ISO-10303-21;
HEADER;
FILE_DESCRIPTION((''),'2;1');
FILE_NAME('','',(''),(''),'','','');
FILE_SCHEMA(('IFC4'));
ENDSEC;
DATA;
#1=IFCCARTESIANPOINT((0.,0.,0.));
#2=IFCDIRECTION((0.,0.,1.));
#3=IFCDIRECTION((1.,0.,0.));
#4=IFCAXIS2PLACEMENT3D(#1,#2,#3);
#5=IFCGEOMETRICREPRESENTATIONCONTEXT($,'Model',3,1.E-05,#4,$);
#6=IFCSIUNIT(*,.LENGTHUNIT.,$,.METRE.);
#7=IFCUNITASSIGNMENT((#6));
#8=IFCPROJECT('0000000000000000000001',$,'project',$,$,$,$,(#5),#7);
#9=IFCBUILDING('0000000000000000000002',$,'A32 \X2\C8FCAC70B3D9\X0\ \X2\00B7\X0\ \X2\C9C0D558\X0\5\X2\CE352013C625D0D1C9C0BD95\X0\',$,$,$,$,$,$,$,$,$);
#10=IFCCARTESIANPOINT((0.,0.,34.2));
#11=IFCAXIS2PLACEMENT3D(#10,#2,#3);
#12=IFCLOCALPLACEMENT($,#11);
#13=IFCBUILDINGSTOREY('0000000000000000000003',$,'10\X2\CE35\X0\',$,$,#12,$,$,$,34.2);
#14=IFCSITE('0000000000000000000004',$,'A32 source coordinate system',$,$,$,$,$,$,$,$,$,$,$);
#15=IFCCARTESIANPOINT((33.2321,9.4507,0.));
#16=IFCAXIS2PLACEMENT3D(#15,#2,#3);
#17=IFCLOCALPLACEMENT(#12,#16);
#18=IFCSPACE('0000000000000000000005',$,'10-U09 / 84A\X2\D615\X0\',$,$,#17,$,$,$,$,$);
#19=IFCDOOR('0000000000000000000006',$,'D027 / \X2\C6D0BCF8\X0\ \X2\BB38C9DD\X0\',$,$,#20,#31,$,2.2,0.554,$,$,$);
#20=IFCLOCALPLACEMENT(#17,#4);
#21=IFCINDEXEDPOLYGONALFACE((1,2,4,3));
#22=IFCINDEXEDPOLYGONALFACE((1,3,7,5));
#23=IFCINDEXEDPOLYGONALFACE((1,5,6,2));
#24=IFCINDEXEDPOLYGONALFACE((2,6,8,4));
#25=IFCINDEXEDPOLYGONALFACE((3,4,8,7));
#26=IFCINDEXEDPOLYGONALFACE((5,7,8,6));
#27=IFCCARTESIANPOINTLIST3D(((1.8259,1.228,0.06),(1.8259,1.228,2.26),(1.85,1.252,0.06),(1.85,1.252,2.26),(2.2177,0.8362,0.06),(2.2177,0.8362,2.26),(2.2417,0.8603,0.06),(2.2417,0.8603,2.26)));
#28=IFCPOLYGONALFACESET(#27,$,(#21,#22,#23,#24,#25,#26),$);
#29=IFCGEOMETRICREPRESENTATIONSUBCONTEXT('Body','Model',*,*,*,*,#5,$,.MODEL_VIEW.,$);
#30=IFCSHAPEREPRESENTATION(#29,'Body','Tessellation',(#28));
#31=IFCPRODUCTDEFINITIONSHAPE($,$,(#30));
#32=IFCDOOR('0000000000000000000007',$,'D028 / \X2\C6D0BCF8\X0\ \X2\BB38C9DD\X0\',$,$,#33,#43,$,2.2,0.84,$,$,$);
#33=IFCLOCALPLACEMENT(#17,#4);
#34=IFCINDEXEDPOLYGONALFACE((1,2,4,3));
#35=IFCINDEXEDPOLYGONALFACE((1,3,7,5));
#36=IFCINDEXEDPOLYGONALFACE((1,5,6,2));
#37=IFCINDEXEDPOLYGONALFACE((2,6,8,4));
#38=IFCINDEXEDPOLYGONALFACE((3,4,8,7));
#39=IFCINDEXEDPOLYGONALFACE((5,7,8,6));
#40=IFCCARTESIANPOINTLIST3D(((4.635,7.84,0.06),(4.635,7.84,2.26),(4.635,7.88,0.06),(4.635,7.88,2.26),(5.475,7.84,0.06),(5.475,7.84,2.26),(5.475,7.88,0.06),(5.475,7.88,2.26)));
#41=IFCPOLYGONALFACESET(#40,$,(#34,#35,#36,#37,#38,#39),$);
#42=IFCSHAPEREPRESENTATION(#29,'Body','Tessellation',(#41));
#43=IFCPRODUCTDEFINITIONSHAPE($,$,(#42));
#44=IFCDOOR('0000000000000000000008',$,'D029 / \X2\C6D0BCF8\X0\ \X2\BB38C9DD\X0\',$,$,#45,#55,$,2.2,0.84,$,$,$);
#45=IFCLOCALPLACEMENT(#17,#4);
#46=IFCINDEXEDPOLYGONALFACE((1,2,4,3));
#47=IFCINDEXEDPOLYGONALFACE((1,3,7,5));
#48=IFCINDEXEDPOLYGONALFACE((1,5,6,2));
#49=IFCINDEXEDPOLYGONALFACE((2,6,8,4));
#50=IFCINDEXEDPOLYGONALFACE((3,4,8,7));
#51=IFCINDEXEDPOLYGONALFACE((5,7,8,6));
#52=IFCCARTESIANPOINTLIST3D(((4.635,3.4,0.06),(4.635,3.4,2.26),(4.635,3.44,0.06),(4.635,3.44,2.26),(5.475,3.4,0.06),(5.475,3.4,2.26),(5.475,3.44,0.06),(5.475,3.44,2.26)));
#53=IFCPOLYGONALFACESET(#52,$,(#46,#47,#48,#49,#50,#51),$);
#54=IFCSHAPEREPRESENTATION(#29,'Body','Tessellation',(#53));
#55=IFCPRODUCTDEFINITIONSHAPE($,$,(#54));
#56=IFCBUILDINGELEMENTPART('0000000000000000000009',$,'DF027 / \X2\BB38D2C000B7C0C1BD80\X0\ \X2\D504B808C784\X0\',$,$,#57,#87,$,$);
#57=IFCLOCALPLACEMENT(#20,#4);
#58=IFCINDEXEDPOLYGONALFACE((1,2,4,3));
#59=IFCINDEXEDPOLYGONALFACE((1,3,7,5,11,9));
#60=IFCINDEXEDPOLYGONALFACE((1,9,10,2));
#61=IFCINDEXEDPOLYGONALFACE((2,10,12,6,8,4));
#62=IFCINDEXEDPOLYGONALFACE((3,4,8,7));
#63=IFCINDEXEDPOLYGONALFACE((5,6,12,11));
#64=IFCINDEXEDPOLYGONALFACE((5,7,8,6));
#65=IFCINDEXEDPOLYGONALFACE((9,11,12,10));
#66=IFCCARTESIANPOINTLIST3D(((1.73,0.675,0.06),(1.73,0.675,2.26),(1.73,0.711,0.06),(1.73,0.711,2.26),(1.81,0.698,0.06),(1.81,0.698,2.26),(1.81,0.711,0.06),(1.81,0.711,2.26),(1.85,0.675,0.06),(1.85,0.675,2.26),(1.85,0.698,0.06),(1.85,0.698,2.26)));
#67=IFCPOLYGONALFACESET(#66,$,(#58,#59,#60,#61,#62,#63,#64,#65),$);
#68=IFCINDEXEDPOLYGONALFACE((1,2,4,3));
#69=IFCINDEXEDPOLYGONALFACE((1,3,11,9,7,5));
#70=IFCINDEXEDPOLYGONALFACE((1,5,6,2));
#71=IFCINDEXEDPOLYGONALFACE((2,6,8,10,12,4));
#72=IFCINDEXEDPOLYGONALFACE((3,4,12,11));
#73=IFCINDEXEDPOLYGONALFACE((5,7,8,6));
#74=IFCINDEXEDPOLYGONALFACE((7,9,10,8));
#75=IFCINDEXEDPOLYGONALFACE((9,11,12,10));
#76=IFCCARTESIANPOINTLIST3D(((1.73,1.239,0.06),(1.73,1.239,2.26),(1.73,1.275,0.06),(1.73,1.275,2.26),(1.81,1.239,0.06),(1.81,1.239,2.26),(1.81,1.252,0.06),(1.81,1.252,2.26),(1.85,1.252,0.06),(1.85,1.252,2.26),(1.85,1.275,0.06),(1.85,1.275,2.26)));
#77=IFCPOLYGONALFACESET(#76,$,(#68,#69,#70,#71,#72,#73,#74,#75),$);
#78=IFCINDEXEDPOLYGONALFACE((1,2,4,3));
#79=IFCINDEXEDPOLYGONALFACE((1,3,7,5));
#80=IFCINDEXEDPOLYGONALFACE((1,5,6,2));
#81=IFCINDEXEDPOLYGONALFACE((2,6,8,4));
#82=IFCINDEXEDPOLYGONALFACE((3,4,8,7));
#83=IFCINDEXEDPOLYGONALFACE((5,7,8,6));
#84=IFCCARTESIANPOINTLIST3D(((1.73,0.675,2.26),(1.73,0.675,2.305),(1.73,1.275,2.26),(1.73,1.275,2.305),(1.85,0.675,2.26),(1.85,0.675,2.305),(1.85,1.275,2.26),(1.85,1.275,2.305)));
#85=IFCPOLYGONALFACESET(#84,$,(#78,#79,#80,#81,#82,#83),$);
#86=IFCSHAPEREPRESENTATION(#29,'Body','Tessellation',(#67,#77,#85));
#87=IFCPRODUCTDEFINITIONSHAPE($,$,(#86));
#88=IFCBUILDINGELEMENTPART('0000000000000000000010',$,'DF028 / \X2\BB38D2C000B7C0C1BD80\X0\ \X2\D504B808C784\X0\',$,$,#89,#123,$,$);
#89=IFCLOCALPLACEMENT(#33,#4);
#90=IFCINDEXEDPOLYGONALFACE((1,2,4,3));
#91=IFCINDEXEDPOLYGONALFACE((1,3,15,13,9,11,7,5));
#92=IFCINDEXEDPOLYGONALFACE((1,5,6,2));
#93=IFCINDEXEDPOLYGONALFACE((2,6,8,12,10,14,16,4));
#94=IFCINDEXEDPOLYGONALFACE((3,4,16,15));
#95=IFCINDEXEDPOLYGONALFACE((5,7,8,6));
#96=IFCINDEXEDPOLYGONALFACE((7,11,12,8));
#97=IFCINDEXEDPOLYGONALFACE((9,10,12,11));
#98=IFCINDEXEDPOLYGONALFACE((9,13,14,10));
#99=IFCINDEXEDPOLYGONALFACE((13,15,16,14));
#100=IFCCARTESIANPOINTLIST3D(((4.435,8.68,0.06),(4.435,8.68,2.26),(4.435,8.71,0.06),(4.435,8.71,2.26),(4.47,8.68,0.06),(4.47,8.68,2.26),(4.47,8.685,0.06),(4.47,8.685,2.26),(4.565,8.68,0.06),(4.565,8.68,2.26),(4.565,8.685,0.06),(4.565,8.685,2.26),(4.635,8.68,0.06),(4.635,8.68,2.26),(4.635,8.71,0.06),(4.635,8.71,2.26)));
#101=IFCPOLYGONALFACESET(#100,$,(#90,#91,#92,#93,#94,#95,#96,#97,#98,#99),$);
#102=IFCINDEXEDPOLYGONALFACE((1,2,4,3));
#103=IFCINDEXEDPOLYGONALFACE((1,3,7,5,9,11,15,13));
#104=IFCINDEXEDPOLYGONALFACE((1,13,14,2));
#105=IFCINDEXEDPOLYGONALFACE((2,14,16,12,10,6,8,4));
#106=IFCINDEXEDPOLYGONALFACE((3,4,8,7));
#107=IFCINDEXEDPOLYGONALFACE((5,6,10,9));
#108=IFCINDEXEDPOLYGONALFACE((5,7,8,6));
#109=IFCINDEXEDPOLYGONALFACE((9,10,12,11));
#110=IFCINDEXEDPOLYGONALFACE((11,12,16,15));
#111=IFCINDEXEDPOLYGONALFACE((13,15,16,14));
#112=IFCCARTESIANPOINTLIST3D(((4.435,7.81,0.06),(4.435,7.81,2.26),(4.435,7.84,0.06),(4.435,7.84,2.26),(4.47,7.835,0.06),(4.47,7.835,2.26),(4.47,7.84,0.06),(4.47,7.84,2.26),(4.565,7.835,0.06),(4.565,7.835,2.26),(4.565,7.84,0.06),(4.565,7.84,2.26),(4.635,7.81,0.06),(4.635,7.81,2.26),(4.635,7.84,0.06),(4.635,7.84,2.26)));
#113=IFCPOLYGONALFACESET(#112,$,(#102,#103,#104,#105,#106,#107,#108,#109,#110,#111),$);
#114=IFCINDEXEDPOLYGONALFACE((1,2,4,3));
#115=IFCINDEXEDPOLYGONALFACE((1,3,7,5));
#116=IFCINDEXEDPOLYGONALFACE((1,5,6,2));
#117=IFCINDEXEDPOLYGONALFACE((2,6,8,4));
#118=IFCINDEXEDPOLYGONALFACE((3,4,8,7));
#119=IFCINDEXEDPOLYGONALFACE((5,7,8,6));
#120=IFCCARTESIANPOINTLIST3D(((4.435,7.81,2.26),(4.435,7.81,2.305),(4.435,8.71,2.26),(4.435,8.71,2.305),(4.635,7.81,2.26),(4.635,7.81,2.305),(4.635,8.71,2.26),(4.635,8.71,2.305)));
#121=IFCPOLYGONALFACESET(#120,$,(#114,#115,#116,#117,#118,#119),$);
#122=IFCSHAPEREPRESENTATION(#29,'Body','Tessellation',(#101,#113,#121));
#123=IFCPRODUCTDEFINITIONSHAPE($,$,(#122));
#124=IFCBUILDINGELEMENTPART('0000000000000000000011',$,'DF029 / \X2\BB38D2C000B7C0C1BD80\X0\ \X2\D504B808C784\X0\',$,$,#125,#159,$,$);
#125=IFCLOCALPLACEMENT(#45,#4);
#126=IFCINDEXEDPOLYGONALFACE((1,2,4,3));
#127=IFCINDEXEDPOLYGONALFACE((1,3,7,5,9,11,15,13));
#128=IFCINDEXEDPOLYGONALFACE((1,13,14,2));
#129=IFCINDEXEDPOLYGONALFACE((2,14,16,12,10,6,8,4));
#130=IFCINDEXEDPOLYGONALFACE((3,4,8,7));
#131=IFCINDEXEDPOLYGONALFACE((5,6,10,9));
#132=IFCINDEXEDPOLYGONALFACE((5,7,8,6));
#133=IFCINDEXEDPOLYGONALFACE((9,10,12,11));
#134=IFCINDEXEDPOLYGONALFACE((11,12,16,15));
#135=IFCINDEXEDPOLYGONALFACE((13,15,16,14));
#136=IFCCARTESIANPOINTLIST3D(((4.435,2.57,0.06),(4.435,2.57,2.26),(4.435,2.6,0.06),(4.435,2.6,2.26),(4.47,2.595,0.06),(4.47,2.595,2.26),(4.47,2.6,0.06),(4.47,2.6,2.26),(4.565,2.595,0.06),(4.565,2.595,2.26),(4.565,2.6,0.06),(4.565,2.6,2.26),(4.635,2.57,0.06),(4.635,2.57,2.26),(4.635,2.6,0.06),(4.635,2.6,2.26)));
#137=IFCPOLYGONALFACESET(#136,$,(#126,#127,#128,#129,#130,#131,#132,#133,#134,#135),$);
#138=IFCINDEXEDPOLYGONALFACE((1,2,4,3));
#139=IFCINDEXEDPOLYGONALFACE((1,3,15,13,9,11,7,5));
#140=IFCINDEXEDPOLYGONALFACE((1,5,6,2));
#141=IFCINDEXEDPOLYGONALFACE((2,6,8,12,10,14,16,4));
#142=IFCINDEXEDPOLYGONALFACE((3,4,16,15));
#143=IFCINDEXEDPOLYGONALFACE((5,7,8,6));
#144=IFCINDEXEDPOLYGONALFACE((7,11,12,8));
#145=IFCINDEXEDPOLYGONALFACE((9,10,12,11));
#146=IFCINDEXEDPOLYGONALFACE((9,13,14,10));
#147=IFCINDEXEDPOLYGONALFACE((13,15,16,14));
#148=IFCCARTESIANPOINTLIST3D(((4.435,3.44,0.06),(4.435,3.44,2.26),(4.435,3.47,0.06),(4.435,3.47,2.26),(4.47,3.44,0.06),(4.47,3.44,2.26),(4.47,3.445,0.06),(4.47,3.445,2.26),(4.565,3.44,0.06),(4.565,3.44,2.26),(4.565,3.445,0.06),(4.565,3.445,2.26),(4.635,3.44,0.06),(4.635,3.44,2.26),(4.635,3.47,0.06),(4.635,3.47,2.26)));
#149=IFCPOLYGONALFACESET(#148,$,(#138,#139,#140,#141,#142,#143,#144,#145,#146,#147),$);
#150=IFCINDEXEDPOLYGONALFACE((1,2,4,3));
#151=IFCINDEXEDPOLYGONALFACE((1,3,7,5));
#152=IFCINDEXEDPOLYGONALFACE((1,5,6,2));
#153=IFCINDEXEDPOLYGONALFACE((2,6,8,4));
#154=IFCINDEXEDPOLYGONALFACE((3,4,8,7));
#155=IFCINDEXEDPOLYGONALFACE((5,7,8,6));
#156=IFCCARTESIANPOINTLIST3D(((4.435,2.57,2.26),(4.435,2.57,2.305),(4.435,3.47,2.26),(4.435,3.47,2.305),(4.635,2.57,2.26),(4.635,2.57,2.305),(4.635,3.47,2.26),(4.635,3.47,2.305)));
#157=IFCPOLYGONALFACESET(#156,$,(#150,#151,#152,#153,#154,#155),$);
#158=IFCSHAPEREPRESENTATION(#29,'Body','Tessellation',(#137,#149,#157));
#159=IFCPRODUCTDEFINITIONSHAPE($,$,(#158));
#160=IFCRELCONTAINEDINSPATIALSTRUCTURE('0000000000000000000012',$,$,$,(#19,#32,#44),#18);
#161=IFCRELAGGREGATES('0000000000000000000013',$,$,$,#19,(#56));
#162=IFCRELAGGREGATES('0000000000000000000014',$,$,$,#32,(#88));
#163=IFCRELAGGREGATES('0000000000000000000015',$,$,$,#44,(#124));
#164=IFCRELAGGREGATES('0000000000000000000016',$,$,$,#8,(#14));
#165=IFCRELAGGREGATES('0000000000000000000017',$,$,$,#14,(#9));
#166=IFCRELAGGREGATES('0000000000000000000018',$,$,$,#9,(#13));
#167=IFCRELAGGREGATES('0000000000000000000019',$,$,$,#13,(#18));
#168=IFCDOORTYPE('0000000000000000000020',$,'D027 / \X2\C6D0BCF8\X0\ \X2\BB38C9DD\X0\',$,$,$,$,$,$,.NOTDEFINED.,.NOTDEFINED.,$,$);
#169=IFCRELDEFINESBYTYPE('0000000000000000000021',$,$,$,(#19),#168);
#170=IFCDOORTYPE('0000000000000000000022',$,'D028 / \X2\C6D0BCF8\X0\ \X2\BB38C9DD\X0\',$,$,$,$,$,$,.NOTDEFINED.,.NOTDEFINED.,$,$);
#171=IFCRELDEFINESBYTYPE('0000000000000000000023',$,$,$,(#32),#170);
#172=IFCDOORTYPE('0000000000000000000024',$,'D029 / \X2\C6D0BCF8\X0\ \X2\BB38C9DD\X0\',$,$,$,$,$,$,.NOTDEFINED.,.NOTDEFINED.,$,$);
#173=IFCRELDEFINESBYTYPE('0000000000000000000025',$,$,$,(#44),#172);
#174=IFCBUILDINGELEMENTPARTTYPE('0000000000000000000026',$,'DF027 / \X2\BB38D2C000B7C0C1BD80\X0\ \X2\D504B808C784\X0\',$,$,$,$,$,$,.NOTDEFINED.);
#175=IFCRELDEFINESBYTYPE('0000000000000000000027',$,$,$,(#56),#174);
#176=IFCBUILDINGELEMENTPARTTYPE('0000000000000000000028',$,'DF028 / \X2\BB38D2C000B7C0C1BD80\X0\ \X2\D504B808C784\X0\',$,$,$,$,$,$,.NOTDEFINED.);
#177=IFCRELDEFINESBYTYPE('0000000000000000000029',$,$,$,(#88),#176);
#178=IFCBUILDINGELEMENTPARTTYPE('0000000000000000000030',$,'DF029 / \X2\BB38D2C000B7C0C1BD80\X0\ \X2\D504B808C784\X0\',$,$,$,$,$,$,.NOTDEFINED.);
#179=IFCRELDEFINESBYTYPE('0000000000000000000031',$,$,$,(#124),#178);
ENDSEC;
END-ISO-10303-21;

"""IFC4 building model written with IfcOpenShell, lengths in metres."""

from ifc_helpers import new_model, si_unit, frame, origin, origin_with_axes, place, context, subcontext, project, spatial, polyline, outline, extrude, source, transform, mapped, type_object, type_shapes, element, aggregate, save


model = new_model("IFC4")

# Units and contexts
model_context = context("Model", 3, precision=1e-05, world=origin_with_axes())
body_context = subcontext(model_context, "Body", "Model", "MODEL_VIEW")
ifc_project = project(units=[si_unit("LENGTHUNIT", "METRE")], contexts=[model_context])

# Site, building, storey, space
storey_placement = place(None, frame((0.0, 0.0, 34.2), z_axis=(0.0, 0.0, 1.0), x_axis=(1.0, 0.0, 0.0)))
space_placement = place(storey_placement, frame((33.2321, 9.4507, 0.0), z_axis=(0.0, 0.0, 1.0), x_axis=(1.0, 0.0, 0.0)))
site = spatial("IfcSite", under=ifc_project, Name="A32 source coordinate system")
building = spatial("IfcBuilding", under=site, Name="A32 주거동 · 지하5층–옥탑지붕")
storey = spatial("IfcBuildingStorey", under=building, at=storey_placement, Name="10층", Elevation=34.2)
space = spatial("IfcSpace", under=storey, at=space_placement, Name="10-U09 / 84A형")

# Doors
door_type_1 = type_object("IfcDoorType", Name="D027 / 원본 문짝", OperationType="NOTDEFINED", PredefinedType="NOTDEFINED")
shared_shape_1 = source(origin(), body_context, "Body", "SweptSolid", [
    extrude(outline(polyline([(1.85, 1.252), (2.2417, 0.8603), (2.2177, 0.8362), (1.8259, 1.228), (1.85, 1.252)])), frame((0.0, 0.0, 0.06)), (0.0, 0.0, 1.0), 2.2),
])
type_shapes(door_type_1, [shared_shape_1])
door_1_placement = place(space_placement, origin_with_axes())
door_1 = element("IfcDoor", 1, at=door_1_placement, inside=space, type_object=door_type_1, Name="D027 / 원본 문짝", OverallHeight=2.2, OverallWidth=0.554, context=body_context, shape_type="MappedRepresentation", body=[
    mapped(shared_shape_1, transform((0.0, 0.0, 0.0), scale=1.0)),
])
door_type_2 = type_object("IfcDoorType", Name="D028 / 원본 문짝", OperationType="NOTDEFINED", PredefinedType="NOTDEFINED")
shared_shape_2 = source(origin(), body_context, "Body", "SweptSolid", [
    extrude(outline(polyline([(5.475, 7.88), (5.475, 7.84), (4.635, 7.84), (4.635, 7.88), (5.475, 7.88)])), frame((0.0, 0.0, 0.06)), (0.0, 0.0, 1.0), 2.2),
])
type_shapes(door_type_2, [shared_shape_2])
door_2_placement = place(space_placement, origin_with_axes())
door_2 = element("IfcDoor", 2, at=door_2_placement, inside=space, type_object=door_type_2, Name="D028 / 원본 문짝", OverallHeight=2.2, OverallWidth=0.84, context=body_context, shape_type="MappedRepresentation", body=[
    mapped(shared_shape_2, transform((0.0, 0.0, 0.0), scale=1.0)),
])
door_type_3 = type_object("IfcDoorType", Name="D029 / 원본 문짝", OperationType="NOTDEFINED", PredefinedType="NOTDEFINED")
shared_shape_3 = source(origin(), body_context, "Body", "SweptSolid", [
    extrude(outline(polyline([(4.635, 3.44), (5.475, 3.44), (5.475, 3.4), (4.635, 3.4), (4.635, 3.44)])), frame((0.0, 0.0, 0.06)), (0.0, 0.0, 1.0), 2.2),
])
type_shapes(door_type_3, [shared_shape_3])
door_3_placement = place(space_placement, origin_with_axes())
door_3 = element("IfcDoor", 3, at=door_3_placement, inside=space, type_object=door_type_3, Name="D029 / 원본 문짝", OverallHeight=2.2, OverallWidth=0.84, context=body_context, shape_type="MappedRepresentation", body=[
    mapped(shared_shape_3, transform((0.0, 0.0, 0.0), scale=1.0)),
])

# Building element parts
building_element_part_type_1 = type_object("IfcBuildingElementPartType", Name="DF027 / 문틀·상부 프레임", PredefinedType="NOTDEFINED")
shared_shape_4 = source(origin(), body_context, "Body", "SweptSolid", [
    extrude(outline(polyline([(1.73, 0.711), (1.81, 0.711), (1.81, 0.698), (1.85, 0.698), (1.85, 0.675), (1.73, 0.675), (1.73, 0.711)])), frame((0.0, 0.0, 0.06)), (0.0, 0.0, 1.0), 2.2),
    extrude(outline(polyline([(1.85, 1.275), (1.85, 1.252), (1.81, 1.252), (1.81, 1.239), (1.73, 1.239), (1.73, 1.275), (1.85, 1.275)])), frame((0.0, 0.0, 0.06)), (0.0, 0.0, 1.0), 2.2),
    extrude(outline(polyline([(1.73, 0.675), (1.73, 1.275), (1.85, 1.275), (1.85, 0.675), (1.73, 0.675)])), frame((0.0, 0.0, 2.26)), (0.0, 0.0, 1.0), 0.045),
])
type_shapes(building_element_part_type_1, [shared_shape_4])
building_element_part_1_placement = place(door_1_placement, origin_with_axes())
building_element_part_1 = element("IfcBuildingElementPart", 4, at=building_element_part_1_placement, type_object=building_element_part_type_1, Name="DF027 / 문틀·상부 프레임", context=body_context, shape_type="MappedRepresentation", body=[
    mapped(shared_shape_4, transform((0.0, 0.0, 0.0), scale=1.0)),
])
aggregate(door_1, [building_element_part_1])
building_element_part_type_2 = type_object("IfcBuildingElementPartType", Name="DF028 / 문틀·상부 프레임", PredefinedType="NOTDEFINED")
shared_shape_5 = source(origin(), body_context, "Body", "SweptSolid", [
    extrude(outline(polyline([(4.635, 8.68), (4.565, 8.68), (4.565, 8.685), (4.47, 8.685), (4.47, 8.68), (4.435, 8.68), (4.435, 8.71), (4.635, 8.71), (4.635, 8.68)])), frame((0.0, 0.0, 0.06)), (0.0, 0.0, 1.0), 2.2),
    extrude(outline(polyline([(4.435, 7.81), (4.435, 7.84), (4.47, 7.84), (4.47, 7.835), (4.565, 7.835), (4.565, 7.84), (4.635, 7.84), (4.635, 7.81), (4.435, 7.81)])), frame((0.0, 0.0, 0.06)), (0.0, 0.0, 1.0), 2.2),
    extrude(outline(polyline([(4.435, 7.81), (4.435, 8.71), (4.635, 8.71), (4.635, 7.81), (4.435, 7.81)])), frame((0.0, 0.0, 2.26)), (0.0, 0.0, 1.0), 0.045),
])
type_shapes(building_element_part_type_2, [shared_shape_5])
building_element_part_2_placement = place(door_2_placement, origin_with_axes())
building_element_part_2 = element("IfcBuildingElementPart", 5, at=building_element_part_2_placement, type_object=building_element_part_type_2, Name="DF028 / 문틀·상부 프레임", context=body_context, shape_type="MappedRepresentation", body=[
    mapped(shared_shape_5, transform((0.0, 0.0, 0.0), scale=1.0)),
])
aggregate(door_2, [building_element_part_2])
building_element_part_type_3 = type_object("IfcBuildingElementPartType", Name="DF029 / 문틀·상부 프레임", PredefinedType="NOTDEFINED")
shared_shape_6 = source(origin(), body_context, "Body", "SweptSolid", [
    extrude(outline(polyline([(4.435, 2.57), (4.435, 2.6), (4.47, 2.6), (4.47, 2.595), (4.565, 2.595), (4.565, 2.6), (4.635, 2.6), (4.635, 2.57), (4.435, 2.57)])), frame((0.0, 0.0, 0.06)), (0.0, 0.0, 1.0), 2.2),
    extrude(outline(polyline([(4.635, 3.44), (4.565, 3.44), (4.565, 3.445), (4.47, 3.445), (4.47, 3.44), (4.435, 3.44), (4.435, 3.47), (4.635, 3.47), (4.635, 3.44)])), frame((0.0, 0.0, 0.06)), (0.0, 0.0, 1.0), 2.2),
    extrude(outline(polyline([(4.435, 2.57), (4.435, 3.47), (4.635, 3.47), (4.635, 2.57), (4.435, 2.57)])), frame((0.0, 0.0, 2.26)), (0.0, 0.0, 1.0), 0.045),
])
type_shapes(building_element_part_type_3, [shared_shape_6])
building_element_part_3_placement = place(door_3_placement, origin_with_axes())
building_element_part_3 = element("IfcBuildingElementPart", 6, at=building_element_part_3_placement, type_object=building_element_part_type_3, Name="DF029 / 문틀·상부 프레임", context=body_context, shape_type="MappedRepresentation", body=[
    mapped(shared_shape_6, transform((0.0, 0.0, 0.0), scale=1.0)),
])
aggregate(door_3, [building_element_part_3])

save(model, "model.ifc")
